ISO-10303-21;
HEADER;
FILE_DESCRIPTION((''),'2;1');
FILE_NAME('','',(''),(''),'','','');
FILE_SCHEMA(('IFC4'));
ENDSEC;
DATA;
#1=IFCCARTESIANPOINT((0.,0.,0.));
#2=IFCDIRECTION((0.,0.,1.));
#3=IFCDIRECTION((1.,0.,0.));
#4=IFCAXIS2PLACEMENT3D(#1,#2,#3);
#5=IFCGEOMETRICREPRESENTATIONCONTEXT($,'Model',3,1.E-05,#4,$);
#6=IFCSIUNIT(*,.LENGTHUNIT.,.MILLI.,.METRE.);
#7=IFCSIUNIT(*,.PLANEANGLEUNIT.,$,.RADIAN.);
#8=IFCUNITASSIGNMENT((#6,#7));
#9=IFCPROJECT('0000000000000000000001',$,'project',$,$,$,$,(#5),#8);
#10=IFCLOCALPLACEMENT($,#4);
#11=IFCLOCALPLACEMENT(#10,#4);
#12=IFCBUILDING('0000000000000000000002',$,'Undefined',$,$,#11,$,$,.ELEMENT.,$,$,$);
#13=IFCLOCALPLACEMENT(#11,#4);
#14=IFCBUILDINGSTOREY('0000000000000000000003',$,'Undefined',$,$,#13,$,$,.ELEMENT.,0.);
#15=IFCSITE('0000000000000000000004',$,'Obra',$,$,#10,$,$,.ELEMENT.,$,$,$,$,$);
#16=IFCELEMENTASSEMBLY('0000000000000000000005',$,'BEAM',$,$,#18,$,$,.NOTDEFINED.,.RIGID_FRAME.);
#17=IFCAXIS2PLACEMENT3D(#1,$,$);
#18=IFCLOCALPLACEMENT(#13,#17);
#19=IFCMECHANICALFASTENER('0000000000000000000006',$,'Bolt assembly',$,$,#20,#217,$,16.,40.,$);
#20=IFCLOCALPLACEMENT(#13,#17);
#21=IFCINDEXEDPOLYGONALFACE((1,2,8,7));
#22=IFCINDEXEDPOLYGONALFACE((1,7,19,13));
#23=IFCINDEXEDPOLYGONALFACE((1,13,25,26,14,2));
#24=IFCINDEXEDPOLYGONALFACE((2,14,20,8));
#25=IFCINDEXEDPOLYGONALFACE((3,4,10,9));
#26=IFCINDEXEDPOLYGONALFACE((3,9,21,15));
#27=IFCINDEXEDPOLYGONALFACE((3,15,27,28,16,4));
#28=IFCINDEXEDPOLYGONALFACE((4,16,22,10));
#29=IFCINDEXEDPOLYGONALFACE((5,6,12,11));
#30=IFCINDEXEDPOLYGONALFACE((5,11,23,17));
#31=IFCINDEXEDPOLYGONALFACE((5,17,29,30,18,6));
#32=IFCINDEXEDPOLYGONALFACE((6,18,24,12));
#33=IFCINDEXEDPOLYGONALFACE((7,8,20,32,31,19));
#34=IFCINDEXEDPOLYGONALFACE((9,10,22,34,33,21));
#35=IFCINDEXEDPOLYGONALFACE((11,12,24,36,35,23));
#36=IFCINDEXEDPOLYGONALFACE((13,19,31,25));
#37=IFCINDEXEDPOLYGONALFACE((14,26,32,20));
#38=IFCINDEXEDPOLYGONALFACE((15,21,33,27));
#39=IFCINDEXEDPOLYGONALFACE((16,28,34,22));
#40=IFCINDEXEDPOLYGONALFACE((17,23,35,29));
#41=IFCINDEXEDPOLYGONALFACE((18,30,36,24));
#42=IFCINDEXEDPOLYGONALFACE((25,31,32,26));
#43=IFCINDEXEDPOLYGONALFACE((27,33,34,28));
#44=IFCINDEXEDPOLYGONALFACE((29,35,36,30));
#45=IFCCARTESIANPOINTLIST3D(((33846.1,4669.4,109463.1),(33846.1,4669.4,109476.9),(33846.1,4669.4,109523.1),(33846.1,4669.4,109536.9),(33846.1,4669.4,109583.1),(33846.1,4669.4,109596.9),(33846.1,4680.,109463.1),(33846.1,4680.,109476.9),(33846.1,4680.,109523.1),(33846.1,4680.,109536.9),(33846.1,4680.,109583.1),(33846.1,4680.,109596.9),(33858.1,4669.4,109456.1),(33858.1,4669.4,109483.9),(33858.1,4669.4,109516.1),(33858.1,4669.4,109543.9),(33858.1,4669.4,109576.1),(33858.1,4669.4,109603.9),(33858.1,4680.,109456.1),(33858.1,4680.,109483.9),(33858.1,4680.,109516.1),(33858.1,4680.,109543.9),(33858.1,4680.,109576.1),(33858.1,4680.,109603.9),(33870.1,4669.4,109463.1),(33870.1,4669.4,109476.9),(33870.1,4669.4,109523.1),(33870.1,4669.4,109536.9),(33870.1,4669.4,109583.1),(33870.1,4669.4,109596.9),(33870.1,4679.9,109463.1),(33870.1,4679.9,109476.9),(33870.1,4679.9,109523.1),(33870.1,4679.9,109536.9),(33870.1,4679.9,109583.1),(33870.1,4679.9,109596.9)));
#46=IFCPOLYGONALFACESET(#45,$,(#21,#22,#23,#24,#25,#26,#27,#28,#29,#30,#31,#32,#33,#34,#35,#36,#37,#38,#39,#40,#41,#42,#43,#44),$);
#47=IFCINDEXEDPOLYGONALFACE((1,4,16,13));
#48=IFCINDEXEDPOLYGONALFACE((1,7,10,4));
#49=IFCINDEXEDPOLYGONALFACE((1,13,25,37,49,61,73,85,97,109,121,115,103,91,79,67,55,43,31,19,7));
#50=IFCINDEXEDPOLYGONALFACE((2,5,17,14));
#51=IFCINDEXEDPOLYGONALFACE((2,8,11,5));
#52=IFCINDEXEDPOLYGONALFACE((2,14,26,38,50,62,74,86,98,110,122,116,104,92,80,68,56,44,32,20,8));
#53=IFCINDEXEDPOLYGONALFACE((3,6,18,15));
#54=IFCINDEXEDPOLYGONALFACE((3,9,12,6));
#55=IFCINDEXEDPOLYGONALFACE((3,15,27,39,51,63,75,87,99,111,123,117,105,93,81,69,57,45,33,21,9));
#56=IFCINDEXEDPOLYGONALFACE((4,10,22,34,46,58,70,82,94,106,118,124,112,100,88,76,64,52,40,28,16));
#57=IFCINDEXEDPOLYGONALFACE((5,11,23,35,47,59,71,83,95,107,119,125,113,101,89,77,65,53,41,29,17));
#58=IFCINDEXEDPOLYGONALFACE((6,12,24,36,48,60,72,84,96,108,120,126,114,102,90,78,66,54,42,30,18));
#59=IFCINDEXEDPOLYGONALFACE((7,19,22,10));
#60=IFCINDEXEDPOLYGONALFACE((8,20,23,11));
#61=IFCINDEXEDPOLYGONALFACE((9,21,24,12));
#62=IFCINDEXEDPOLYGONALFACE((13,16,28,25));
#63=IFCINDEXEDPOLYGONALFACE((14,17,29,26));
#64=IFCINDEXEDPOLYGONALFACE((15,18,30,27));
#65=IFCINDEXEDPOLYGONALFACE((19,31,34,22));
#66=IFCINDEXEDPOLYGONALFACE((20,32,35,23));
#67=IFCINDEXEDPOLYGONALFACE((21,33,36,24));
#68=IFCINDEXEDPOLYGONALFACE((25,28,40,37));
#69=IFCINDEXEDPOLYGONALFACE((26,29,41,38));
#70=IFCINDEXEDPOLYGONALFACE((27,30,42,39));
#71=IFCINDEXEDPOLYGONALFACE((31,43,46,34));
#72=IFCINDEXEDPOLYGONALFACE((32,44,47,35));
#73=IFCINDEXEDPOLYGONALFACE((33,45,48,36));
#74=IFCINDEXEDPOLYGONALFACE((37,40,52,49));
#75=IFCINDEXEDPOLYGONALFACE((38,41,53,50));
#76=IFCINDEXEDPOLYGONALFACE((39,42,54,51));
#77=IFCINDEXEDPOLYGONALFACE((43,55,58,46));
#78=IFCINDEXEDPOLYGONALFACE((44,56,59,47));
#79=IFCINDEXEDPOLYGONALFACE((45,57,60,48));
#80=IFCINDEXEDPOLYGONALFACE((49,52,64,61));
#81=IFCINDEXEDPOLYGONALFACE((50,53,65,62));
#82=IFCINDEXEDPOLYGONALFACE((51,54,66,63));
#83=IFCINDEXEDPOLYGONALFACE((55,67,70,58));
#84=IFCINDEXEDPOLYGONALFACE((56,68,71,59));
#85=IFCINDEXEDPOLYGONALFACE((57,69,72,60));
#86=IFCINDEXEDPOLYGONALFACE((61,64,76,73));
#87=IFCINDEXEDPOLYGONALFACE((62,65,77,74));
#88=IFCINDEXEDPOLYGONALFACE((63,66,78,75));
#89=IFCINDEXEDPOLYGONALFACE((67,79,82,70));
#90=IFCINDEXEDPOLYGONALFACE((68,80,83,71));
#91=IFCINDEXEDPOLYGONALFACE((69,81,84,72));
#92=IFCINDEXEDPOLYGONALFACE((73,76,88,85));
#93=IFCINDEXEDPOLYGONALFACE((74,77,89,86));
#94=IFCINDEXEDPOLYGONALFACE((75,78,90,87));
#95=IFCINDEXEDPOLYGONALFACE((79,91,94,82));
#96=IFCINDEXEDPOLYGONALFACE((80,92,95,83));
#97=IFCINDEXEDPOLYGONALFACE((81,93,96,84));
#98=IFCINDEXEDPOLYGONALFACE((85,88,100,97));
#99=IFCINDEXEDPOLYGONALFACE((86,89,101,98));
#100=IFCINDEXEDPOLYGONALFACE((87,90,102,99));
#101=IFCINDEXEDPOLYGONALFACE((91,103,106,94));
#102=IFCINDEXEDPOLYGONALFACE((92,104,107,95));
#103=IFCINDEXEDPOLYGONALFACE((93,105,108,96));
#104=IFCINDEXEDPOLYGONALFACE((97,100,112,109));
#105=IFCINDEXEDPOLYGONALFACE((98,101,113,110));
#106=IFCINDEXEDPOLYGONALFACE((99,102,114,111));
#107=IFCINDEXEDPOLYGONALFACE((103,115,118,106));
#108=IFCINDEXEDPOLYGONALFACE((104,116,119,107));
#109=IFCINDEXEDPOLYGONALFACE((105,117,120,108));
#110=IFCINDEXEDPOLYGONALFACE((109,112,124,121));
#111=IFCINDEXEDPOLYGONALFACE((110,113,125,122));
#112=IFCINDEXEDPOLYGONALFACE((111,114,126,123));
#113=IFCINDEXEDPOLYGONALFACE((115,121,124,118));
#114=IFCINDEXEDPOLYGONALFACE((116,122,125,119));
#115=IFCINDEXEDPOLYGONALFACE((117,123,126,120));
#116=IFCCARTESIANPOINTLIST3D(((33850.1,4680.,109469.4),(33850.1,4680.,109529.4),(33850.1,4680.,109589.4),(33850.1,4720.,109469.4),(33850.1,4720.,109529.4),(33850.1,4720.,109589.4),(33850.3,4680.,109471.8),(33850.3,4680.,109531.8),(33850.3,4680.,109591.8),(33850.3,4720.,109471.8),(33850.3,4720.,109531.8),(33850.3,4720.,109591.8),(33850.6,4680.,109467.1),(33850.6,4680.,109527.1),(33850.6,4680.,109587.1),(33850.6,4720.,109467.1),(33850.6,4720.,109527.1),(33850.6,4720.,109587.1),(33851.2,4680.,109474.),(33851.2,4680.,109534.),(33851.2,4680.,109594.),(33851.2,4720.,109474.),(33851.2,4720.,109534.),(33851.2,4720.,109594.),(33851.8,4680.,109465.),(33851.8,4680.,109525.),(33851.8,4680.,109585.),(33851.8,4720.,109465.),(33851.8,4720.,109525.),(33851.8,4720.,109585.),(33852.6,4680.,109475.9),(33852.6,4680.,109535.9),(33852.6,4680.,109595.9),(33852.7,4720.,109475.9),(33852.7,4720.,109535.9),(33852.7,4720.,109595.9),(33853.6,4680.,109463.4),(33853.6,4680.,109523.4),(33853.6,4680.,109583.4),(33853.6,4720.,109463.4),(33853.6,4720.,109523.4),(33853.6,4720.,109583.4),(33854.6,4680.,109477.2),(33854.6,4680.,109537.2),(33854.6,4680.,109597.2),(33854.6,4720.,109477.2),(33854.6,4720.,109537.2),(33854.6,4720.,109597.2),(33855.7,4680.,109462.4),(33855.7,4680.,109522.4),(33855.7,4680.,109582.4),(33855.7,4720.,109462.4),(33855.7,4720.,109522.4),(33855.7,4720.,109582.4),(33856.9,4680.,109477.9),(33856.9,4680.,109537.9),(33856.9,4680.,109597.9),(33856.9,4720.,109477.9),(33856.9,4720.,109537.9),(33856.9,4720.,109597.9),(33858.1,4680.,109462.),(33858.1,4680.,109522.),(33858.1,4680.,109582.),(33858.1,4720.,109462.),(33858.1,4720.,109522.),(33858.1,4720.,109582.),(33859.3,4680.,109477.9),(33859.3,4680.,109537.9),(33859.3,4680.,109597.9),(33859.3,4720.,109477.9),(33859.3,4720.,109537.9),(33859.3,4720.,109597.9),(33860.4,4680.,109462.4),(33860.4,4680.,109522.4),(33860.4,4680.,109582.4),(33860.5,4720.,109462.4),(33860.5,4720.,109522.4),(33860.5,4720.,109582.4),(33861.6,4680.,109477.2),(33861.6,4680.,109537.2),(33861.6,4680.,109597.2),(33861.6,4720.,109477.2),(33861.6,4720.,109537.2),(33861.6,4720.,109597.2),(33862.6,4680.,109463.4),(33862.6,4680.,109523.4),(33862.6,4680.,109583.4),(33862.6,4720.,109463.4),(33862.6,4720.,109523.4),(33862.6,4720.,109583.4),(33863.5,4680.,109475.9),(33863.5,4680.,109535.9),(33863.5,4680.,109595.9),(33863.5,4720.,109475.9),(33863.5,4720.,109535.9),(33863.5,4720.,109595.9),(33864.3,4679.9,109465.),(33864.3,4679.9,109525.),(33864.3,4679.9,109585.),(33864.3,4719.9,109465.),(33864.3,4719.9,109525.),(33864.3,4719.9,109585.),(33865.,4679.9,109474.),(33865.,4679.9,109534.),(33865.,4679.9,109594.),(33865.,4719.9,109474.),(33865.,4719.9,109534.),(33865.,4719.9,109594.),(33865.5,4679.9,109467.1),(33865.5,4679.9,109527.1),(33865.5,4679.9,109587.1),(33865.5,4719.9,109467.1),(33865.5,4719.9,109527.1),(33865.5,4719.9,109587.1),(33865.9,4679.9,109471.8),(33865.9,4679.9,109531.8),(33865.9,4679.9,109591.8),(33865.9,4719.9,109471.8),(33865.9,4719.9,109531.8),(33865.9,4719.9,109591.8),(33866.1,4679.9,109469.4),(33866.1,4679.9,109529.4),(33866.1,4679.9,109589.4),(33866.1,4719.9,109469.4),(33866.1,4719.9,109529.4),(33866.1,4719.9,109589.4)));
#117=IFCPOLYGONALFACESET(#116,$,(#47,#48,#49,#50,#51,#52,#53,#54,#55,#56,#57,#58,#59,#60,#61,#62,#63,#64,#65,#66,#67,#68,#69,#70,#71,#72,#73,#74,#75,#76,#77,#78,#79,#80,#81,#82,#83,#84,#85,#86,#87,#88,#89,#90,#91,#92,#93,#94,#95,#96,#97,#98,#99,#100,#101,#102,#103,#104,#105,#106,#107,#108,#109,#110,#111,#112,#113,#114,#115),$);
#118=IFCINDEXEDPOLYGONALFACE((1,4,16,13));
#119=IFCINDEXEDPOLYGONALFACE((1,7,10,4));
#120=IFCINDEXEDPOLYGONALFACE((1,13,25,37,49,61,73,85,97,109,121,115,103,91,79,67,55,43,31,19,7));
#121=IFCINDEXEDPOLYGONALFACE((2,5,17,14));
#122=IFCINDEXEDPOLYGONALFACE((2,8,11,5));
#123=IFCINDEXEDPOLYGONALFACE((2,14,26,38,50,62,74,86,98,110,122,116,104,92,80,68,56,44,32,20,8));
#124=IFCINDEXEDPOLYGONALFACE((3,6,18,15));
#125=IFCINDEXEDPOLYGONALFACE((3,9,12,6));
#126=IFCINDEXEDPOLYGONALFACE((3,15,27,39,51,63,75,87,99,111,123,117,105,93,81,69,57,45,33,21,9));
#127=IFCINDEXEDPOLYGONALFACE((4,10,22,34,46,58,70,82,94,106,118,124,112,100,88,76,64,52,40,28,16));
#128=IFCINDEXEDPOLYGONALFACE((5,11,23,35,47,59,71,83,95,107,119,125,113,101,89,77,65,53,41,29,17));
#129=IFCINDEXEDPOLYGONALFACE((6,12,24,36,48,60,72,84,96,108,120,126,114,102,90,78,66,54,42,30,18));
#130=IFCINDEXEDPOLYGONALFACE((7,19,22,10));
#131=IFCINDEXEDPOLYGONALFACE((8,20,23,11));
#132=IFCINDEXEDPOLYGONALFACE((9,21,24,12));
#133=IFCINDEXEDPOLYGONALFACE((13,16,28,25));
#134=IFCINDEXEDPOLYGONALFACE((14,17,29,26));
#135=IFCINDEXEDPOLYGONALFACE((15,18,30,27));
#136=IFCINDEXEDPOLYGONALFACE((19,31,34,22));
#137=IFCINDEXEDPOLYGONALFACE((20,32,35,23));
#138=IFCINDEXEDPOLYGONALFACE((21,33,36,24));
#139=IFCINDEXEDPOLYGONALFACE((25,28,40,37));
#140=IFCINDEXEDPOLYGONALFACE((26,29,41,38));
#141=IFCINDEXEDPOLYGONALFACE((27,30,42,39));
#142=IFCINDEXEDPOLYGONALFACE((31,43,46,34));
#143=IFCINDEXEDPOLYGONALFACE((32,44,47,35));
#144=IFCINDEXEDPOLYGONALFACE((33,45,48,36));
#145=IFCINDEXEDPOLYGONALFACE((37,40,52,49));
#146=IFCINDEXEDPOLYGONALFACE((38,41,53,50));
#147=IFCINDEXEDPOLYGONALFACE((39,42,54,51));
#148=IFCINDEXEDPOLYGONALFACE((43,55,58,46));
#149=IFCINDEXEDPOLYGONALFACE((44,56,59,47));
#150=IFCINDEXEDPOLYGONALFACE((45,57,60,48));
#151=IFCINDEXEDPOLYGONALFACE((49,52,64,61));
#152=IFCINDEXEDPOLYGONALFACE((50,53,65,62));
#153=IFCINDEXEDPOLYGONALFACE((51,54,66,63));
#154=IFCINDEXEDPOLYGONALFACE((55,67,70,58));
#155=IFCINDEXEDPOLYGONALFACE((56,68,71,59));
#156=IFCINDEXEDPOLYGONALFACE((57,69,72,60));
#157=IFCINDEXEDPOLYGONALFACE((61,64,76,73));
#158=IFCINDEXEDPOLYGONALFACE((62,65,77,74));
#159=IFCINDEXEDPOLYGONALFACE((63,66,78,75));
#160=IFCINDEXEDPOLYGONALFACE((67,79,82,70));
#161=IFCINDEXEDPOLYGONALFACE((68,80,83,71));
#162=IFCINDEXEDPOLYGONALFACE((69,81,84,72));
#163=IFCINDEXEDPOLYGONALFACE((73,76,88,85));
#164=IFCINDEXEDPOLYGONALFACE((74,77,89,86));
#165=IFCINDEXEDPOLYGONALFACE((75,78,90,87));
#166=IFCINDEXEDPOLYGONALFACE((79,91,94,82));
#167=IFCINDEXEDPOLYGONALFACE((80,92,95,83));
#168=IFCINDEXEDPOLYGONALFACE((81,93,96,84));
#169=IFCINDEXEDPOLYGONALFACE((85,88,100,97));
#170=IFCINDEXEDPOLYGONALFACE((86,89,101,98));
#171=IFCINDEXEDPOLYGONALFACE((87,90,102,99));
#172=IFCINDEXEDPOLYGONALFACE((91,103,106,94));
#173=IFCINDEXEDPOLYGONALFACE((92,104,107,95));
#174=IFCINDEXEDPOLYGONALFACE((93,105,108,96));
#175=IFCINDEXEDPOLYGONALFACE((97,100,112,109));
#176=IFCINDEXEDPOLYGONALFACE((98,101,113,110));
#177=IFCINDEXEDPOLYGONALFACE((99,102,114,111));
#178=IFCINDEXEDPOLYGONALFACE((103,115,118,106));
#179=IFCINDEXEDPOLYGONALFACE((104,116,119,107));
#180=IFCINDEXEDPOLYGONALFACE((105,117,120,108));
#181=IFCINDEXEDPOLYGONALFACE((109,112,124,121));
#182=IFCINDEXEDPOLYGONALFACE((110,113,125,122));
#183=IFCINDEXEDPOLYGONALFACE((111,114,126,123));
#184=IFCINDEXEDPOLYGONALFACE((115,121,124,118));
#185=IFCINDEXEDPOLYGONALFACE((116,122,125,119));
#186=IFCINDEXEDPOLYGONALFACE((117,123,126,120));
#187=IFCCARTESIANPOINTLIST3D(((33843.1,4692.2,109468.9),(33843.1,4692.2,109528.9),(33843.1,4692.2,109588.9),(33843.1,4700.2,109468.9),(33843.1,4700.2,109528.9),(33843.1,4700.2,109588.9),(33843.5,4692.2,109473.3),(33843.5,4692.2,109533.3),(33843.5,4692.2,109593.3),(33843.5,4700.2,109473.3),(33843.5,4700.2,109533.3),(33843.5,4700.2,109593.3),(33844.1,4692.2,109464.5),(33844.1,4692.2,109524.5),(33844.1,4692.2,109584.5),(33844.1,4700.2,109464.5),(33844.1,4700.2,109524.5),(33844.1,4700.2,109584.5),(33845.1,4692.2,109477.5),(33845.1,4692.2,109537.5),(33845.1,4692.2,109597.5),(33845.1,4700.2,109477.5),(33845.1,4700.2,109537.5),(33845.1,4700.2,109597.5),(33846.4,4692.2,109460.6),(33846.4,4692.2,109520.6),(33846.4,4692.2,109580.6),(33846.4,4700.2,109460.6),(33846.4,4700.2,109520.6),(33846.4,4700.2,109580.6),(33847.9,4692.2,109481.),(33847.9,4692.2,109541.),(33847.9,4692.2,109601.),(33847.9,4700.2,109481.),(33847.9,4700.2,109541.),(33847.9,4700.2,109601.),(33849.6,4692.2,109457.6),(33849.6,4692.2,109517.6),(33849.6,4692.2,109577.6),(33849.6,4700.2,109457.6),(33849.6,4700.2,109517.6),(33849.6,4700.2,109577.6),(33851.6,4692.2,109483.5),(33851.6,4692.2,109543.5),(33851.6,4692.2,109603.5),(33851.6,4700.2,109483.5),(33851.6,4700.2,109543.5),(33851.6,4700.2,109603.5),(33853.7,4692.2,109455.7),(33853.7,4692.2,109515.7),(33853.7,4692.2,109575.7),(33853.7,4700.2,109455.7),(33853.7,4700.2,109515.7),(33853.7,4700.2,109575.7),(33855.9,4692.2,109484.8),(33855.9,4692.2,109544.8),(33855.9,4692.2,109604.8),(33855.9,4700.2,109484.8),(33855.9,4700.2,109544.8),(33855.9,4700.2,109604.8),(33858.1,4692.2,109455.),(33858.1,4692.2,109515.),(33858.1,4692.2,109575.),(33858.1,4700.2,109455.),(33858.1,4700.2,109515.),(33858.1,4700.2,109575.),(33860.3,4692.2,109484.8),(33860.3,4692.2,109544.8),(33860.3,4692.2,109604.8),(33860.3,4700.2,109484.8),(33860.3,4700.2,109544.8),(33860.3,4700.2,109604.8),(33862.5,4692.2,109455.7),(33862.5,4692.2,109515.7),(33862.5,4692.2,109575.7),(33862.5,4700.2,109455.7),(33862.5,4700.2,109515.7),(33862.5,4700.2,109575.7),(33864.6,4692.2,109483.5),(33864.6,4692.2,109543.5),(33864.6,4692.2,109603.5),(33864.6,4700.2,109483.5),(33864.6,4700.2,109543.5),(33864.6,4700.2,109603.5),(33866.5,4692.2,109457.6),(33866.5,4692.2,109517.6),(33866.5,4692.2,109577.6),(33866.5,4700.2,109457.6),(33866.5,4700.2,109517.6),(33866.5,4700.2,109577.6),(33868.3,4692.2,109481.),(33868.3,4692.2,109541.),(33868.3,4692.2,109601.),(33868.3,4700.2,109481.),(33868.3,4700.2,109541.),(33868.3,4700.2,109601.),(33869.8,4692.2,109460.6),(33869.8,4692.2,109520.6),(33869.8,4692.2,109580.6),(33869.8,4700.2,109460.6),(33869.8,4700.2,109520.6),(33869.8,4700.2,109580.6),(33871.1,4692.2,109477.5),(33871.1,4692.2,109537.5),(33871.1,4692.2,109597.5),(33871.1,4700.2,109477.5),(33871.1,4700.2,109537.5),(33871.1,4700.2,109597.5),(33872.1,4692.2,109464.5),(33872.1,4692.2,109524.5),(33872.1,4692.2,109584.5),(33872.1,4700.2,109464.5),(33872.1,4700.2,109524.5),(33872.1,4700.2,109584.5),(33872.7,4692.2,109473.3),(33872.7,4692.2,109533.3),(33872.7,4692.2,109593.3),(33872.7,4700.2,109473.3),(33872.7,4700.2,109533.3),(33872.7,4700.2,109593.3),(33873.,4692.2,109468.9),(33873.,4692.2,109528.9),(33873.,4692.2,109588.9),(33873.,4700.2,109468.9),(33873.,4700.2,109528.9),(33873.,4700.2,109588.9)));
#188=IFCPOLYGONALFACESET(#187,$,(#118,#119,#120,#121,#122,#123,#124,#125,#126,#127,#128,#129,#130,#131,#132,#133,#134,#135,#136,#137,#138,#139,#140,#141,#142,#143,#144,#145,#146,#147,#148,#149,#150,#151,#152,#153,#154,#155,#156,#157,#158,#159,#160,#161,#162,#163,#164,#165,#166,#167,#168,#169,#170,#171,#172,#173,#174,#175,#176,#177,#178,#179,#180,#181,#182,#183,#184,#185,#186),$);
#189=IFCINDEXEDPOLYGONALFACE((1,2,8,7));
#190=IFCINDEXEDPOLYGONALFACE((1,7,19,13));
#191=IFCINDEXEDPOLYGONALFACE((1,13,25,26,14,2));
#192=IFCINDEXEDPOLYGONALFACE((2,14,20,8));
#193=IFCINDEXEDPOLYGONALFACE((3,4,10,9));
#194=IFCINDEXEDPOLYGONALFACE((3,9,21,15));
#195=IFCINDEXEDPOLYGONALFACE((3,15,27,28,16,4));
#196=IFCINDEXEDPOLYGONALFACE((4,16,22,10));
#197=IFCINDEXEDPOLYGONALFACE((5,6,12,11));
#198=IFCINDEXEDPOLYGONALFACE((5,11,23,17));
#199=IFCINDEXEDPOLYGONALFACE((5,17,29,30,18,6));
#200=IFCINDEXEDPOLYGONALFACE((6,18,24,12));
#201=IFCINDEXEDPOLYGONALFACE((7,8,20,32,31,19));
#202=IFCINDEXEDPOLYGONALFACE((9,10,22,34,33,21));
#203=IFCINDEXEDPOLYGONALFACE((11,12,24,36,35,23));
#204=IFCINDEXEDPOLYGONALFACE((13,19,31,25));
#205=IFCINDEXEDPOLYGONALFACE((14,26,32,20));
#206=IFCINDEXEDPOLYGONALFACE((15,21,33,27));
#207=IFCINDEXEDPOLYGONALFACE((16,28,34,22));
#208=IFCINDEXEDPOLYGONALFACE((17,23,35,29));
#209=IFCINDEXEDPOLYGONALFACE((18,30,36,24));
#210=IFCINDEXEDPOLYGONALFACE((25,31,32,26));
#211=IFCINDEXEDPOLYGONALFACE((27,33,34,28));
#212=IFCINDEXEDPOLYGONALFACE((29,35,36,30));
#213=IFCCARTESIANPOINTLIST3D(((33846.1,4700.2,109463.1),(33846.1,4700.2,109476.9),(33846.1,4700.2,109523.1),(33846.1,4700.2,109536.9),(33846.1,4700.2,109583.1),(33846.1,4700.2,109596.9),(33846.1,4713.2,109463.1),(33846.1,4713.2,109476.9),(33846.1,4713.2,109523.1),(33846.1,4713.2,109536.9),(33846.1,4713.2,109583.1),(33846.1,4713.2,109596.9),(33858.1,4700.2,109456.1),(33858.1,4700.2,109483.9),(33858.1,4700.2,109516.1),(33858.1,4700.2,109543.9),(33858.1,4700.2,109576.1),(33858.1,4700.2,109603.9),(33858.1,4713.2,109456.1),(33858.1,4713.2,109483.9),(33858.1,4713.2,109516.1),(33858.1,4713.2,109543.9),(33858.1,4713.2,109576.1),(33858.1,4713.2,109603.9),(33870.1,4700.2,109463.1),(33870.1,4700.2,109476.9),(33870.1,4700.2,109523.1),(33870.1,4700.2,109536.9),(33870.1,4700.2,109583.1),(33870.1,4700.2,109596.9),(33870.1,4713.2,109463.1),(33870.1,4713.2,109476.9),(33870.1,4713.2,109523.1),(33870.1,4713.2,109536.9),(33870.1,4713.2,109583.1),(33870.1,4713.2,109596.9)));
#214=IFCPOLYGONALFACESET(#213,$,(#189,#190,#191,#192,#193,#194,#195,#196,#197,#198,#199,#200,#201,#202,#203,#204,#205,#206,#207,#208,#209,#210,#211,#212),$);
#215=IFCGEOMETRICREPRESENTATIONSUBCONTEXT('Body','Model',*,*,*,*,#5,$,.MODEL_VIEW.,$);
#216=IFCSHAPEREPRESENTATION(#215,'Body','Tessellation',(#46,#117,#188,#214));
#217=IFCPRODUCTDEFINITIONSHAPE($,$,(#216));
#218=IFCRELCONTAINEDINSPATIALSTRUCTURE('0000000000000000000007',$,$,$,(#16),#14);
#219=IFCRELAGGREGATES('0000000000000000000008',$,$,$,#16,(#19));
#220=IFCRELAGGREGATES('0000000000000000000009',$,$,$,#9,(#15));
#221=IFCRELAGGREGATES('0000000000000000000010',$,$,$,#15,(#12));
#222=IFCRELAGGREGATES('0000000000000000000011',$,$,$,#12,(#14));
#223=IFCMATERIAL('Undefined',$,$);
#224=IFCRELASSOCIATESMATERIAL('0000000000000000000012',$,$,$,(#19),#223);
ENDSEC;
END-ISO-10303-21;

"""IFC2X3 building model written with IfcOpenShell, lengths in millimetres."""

from ifc_helpers import new_model, si_unit, frame, origin_with_axes, origin_2d_with_axis, place, context, subcontext, project, spatial, polyline, circle, outline, extrude, source, transform, mapped, material, element, aggregate, save


model = new_model("IFC2X3")

# Units and contexts
model_context = context("Model", 3, precision=1e-05, world=origin_with_axes())
body_context = subcontext(model_context, "Body", "Model", "MODEL_VIEW")
ifc_project = project(units=[si_unit("LENGTHUNIT", "METRE", prefix="MILLI"), si_unit("PLANEANGLEUNIT", "RADIAN")], contexts=[model_context])

# Site, building, storey
site_placement = place(None, origin_with_axes())
site = spatial("IfcSite", under=ifc_project, at=site_placement, Name="Obra", CompositionType="ELEMENT")
building_placement = place(site_placement, origin_with_axes())
building = spatial("IfcBuilding", under=site, at=building_placement, Name="Undefined", CompositionType="ELEMENT")
storey_placement = place(building_placement, origin_with_axes())
storey = spatial("IfcBuildingStorey", under=building, at=storey_placement, Name="Undefined", CompositionType="ELEMENT", Elevation=0.0)

# Element assembly
assembly_1_placement = place(storey_placement, origin_with_axes())
assembly_1 = element("IfcElementAssembly", 1, at=assembly_1_placement, inside=storey, Name="BEAM", AssemblyPlace="NOTDEFINED", PredefinedType="RIGID_FRAME")

# Shared definitions
ifc_material_1 = material(Name="Undefined")

# Shared definitions
shared_shape_1 = source(origin_with_axes(), body_context, "Body", "SweptSolid", [
    extrude(outline(polyline([(13.9, 0.0), (6.9, 12.0), (-6.9, 12.0), (-13.9, 0.0), (-6.9, -12.0), (6.9, -12.0), (13.9, 0.0)])), frame((0.0, -19.7, 0.0), z_axis=(0.0, 1.0, 0.0), x_axis=(1.0, 0.0, 0.0)), (0.0, 0.0, 1.0), 10.6),
    extrude(circle(Radius=8.0, at=origin_2d_with_axis()), frame((0.0, -9.1, 0.0), z_axis=(0.0, 1.0, 0.0), x_axis=(1.0, 0.0, 0.0)), (0.0, 0.0, 1.0), 40.0),
    extrude(circle(Radius=15.0, at=origin_2d_with_axis()), frame((0.0, 3.1, 0.0), z_axis=(0.0, 1.0, 0.0), x_axis=(1.0, 0.0, 0.0)), (0.0, 0.0, 1.0), 8.0),
    extrude(outline(polyline([(13.9, 0.0), (6.9, 12.0), (-6.9, 12.0), (-13.9, 0.0), (-6.9, -12.0), (6.9, -12.0), (13.9, 0.0)])), frame((0.0, 11.1, 0.0), z_axis=(0.0, 1.0, 0.0), x_axis=(1.0, 0.0, 0.0)), (0.0, 0.0, 1.0), 13.0),
])

# Mechanical fastener
mechanical_fastener_1_placement = place(assembly_1_placement, frame((33808.1, 4689.1, 109650.0), z_axis=(1.0, -0.000126, 0.0), x_axis=(0.0, 0.0, -1.0)))
mechanical_fastener_1 = element("IfcMechanicalFastener", 2, at=mechanical_fastener_1_placement, material=ifc_material_1, Name="Bolt assembly", NominalDiameter=16.0, NominalLength=40.0, context=body_context, shape_type="MappedRepresentation", body=[
    mapped(shared_shape_1, transform((60.0, 0.0, 50.0))),
    mapped(shared_shape_1, transform((120.0, 0.0, 50.0))),
    mapped(shared_shape_1, transform((180.0, 0.0, 50.0))),
])
aggregate(assembly_1, [mechanical_fastener_1])

save(model, "model.ifc")
